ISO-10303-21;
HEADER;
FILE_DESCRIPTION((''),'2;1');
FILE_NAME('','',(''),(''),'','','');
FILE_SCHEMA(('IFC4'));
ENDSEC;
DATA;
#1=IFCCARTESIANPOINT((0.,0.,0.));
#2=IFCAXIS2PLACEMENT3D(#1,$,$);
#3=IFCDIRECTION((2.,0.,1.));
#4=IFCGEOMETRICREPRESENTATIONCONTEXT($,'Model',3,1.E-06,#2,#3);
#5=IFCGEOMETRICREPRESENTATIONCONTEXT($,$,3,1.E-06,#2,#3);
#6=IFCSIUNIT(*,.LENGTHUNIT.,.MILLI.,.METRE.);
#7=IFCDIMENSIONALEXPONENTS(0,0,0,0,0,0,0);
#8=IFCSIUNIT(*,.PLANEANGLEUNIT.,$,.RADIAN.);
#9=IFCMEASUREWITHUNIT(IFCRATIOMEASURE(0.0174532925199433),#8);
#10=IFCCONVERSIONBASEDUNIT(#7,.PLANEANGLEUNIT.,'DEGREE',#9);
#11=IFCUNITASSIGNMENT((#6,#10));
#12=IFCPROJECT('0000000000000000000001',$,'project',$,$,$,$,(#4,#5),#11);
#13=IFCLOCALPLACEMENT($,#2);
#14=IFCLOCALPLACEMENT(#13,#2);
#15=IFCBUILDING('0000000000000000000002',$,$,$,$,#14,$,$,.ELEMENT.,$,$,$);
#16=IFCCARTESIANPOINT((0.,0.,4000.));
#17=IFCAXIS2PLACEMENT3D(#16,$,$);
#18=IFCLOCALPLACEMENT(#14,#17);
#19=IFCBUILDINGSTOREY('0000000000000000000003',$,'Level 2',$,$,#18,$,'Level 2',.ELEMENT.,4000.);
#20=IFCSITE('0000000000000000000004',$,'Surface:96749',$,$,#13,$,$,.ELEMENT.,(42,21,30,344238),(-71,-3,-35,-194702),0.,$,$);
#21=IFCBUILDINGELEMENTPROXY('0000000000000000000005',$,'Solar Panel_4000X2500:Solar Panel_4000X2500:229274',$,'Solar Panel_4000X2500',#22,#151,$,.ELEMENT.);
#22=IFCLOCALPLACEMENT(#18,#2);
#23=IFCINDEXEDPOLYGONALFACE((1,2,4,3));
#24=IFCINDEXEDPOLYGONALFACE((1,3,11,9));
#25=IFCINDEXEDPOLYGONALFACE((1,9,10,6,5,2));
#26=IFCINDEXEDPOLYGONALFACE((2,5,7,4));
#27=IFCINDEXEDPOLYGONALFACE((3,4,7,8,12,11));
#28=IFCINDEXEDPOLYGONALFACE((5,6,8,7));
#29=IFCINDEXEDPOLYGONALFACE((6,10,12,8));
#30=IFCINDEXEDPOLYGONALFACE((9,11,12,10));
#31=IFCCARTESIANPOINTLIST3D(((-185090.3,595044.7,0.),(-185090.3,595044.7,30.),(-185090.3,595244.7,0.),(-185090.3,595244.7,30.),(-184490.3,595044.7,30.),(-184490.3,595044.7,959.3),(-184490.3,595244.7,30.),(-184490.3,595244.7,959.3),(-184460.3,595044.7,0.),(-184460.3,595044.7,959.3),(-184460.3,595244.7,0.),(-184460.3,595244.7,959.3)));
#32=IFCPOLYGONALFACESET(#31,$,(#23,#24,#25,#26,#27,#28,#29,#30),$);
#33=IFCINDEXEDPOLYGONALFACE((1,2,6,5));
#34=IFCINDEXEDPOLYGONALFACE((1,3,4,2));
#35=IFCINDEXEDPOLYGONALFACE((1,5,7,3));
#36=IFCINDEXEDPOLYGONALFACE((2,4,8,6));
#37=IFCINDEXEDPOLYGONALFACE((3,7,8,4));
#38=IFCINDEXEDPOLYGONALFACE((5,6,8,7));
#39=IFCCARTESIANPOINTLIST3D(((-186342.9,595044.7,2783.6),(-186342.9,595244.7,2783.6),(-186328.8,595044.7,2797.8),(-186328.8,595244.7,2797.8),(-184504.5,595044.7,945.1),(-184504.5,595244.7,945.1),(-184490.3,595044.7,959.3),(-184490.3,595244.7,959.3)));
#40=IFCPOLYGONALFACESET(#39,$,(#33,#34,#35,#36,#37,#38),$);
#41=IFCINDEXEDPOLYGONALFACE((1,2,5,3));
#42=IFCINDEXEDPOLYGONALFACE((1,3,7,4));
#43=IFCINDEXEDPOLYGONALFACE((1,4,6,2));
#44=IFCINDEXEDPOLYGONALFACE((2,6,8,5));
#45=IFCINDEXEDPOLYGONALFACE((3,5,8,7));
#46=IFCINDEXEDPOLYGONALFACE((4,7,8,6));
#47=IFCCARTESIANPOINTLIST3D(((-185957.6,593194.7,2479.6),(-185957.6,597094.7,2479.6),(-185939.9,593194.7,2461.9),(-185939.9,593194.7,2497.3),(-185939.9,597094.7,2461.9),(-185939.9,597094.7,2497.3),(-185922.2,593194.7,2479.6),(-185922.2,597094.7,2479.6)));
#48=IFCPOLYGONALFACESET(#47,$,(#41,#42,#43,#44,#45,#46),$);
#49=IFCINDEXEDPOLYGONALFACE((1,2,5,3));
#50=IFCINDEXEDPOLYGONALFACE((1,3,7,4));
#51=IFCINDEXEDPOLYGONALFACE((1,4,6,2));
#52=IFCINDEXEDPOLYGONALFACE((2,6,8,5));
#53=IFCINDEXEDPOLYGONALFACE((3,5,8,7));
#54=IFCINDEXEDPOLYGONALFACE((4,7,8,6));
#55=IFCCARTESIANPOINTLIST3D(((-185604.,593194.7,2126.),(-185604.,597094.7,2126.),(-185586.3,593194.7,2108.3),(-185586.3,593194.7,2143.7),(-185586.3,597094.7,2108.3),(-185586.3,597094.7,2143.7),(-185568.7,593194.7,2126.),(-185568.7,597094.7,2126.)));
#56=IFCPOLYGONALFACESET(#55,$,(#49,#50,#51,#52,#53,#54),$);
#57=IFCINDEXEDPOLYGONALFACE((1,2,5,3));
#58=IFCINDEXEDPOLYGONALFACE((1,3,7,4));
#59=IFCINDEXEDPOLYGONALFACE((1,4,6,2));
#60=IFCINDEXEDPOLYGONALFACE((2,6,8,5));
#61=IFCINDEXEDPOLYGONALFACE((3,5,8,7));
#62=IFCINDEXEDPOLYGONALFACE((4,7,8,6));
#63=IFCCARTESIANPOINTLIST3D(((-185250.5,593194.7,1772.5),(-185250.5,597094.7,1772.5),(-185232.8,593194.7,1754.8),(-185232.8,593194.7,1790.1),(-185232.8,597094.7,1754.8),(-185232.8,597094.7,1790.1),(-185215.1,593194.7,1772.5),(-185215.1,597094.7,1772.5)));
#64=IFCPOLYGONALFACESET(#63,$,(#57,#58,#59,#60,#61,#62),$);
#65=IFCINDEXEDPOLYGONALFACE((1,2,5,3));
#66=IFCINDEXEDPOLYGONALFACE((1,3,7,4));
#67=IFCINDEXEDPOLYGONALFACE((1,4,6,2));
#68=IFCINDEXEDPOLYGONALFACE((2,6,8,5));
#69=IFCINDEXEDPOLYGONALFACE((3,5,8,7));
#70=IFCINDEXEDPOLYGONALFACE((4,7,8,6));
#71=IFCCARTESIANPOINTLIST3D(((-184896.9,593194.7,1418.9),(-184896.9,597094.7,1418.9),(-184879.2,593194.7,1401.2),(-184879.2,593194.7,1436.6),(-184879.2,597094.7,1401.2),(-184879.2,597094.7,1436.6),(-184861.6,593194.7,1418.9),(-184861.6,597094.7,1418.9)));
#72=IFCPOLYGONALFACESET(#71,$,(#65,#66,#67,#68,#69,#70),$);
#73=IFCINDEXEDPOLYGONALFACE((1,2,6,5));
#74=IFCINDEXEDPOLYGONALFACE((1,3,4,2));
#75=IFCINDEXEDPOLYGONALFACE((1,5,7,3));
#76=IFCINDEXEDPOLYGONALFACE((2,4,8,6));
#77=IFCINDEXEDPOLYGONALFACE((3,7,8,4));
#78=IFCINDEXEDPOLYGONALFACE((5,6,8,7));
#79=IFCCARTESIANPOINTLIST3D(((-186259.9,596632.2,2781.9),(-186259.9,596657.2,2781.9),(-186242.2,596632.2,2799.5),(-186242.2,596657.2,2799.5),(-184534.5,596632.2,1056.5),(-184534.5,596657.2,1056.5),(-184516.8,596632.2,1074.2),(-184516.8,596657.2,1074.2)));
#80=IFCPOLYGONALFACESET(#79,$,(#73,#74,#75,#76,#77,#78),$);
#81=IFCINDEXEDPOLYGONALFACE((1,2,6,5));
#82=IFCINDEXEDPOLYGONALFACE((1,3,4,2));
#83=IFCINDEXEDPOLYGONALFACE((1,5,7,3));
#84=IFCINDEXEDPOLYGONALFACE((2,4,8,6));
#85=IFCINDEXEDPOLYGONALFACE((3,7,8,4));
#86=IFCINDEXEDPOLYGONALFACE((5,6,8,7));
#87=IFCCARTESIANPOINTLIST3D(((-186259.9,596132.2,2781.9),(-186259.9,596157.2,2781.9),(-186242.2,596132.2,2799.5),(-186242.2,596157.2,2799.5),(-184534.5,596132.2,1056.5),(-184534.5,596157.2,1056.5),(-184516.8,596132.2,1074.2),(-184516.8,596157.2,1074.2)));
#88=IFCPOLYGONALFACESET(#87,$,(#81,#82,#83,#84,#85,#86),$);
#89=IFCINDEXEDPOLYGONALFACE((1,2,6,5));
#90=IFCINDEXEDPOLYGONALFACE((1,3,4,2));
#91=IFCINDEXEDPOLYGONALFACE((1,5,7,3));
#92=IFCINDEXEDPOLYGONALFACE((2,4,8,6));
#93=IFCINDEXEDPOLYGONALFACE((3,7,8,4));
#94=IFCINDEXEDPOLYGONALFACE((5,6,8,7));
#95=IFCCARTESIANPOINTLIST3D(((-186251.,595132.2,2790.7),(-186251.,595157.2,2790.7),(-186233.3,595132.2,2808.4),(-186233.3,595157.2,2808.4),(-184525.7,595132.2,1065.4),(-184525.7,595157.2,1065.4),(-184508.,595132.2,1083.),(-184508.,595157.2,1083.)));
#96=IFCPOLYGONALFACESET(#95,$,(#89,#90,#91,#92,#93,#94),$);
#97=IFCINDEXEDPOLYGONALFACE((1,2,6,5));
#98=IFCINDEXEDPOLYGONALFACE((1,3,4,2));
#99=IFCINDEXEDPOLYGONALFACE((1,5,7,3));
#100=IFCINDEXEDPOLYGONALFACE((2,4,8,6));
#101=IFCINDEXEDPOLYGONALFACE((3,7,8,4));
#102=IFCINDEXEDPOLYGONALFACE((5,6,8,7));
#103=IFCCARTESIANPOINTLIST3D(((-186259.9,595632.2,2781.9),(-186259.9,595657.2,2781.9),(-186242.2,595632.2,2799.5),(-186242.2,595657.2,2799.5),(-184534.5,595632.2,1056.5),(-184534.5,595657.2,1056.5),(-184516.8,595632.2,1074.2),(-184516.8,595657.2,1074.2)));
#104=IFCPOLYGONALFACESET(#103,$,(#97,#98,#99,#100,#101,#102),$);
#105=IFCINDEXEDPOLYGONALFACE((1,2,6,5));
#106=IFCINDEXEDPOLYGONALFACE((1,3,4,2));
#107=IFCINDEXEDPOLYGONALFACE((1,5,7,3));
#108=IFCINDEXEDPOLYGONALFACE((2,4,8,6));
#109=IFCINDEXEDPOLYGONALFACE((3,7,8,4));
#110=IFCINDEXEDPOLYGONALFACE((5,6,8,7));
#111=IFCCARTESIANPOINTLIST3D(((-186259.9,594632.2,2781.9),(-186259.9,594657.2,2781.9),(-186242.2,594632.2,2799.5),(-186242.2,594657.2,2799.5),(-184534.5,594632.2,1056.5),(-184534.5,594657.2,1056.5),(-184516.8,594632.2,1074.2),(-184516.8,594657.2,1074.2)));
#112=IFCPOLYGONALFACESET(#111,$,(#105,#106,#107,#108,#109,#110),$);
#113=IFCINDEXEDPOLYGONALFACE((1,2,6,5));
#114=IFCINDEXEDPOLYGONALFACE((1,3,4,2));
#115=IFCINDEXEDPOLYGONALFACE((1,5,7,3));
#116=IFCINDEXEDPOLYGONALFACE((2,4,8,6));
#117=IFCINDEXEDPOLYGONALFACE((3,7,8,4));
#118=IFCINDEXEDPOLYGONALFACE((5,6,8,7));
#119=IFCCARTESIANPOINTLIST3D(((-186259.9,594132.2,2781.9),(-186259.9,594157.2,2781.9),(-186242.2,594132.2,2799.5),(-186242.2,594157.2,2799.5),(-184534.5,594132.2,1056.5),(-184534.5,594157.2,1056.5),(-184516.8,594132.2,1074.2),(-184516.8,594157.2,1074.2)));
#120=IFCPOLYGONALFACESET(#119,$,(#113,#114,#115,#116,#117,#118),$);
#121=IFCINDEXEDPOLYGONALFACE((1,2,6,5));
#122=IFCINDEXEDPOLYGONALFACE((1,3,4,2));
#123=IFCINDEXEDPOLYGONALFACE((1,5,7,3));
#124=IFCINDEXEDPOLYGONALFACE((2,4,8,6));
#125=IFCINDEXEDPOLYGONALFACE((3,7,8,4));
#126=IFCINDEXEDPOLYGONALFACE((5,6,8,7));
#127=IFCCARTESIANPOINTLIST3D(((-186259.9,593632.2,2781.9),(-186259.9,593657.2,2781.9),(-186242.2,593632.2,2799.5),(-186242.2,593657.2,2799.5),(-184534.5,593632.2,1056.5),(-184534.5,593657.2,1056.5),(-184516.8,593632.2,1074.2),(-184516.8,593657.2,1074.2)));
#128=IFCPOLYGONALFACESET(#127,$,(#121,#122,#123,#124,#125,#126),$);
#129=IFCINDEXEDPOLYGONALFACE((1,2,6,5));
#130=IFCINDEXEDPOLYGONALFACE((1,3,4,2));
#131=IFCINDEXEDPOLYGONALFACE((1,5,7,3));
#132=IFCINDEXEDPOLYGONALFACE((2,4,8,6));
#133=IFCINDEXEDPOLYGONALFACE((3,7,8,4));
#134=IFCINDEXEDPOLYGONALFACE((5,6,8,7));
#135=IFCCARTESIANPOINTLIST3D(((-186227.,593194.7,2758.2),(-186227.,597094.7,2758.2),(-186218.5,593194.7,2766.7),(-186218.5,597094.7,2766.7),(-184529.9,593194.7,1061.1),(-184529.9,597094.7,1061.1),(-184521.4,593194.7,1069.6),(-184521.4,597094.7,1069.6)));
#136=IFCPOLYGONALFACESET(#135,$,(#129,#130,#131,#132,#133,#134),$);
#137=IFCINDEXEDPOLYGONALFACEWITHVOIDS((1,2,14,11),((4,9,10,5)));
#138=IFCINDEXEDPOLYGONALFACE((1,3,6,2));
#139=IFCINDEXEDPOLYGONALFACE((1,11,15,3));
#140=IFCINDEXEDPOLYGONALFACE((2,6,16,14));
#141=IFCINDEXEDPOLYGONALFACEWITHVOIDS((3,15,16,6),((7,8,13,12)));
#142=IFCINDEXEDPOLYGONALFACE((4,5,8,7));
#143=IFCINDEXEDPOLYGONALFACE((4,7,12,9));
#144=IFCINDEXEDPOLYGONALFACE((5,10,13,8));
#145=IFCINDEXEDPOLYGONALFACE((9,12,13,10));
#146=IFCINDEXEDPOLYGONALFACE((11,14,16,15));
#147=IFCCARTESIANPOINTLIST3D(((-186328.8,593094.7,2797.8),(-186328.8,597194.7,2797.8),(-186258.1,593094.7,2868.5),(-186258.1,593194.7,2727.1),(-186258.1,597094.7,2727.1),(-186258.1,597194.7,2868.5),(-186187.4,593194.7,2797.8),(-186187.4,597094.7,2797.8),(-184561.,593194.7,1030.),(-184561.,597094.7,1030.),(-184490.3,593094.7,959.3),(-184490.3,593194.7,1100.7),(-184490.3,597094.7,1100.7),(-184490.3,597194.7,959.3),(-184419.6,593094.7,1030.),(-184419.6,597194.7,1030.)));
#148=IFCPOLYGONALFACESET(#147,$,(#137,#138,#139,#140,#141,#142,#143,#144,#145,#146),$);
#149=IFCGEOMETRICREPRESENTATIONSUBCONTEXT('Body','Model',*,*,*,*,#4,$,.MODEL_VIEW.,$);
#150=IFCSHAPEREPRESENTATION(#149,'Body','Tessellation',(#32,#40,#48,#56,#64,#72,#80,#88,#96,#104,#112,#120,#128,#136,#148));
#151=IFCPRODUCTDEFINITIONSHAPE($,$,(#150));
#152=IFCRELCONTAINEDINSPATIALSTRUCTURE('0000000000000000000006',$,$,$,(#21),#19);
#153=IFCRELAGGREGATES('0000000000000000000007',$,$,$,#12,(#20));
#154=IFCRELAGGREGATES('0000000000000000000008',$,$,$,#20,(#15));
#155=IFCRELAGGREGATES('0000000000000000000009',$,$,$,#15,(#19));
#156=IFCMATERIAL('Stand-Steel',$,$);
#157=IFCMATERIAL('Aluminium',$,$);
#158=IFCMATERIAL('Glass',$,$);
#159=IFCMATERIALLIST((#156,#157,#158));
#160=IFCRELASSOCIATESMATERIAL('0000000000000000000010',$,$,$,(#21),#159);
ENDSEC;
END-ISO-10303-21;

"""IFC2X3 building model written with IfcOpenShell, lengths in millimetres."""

from ifc_helpers import new_model, entity, si_unit, converted_unit, direction, frame, frame_2d, origin, origin_2d_with_axis, place, context, subcontext, project, spatial, polyline, rectangle, outline, extrude, source, transform, mapped, material, material_list, element, save


model = new_model("IFC2X3")

# Units and contexts
model_context = context("Model", 3, precision=1e-06, world=origin(), true_north=direction((2.0, 0.0, 1.0)))
context_of_model = context(None, 3, precision=1e-06, world=origin(), true_north=direction((2.0, 0.0, 1.0)))
body_context = subcontext(model_context, "Body", "Model", "MODEL_VIEW")
ifc_project = project(units=[si_unit("LENGTHUNIT", "METRE", prefix="MILLI"), converted_unit("PLANEANGLEUNIT", "DEGREE", entity("IfcRatioMeasure", 0.0174532925199433), si_unit("PLANEANGLEUNIT", "RADIAN"), dimensions=[0, 0, 0, 0, 0, 0, 0])], contexts=[model_context, context_of_model])

# Site, building, storey
site_placement = place(None, origin())
site = spatial("IfcSite", under=ifc_project, at=site_placement, Name="Surface:96749", CompositionType="ELEMENT", RefLatitude=(42, 21, 30, 344238), RefLongitude=(-71, -3, -35, -194702), RefElevation=0.0)
building_placement = place(site_placement, origin())
building = spatial("IfcBuilding", under=site, at=building_placement, CompositionType="ELEMENT")
storey_placement = place(building_placement, frame((0.0, 0.0, 4000.0)))
storey = spatial("IfcBuildingStorey", under=building, at=storey_placement, Name="Level 2", LongName="Level 2", CompositionType="ELEMENT", Elevation=4000.0)

# Building element proxy
ifc_material_1 = material(Name="Stand-Steel")
ifc_material_2 = material(Name="Aluminium")
ifc_material_3 = material(Name="Glass")
shared_shape = source(origin(), body_context, "Body", "SweptSolid", [
    extrude(outline(polyline([(-629.5, -220.0), (329.8, -220.0), (329.8, 410.0), (299.8, 410.0), (299.8, -190.0), (-629.5, -190.0), (-629.5, -220.0)])), frame((-190.0, -100.0, 299.8), z_axis=(0.0, 1.0, 0.0), x_axis=(0.0, 0.0, -1.0)), (0.0, 0.0, 1.0), 200.0),
    extrude(rectangle(XDim=20.0, YDim=200.0, at=frame_2d((0.0, 0.0), x_axis=(0.0, 1.0))), frame((-7.1, 0.0, 922.2), z_axis=(-0.707107, 0.0, 0.707107), x_axis=(0.0, 1.0, 0.0)), (0.0, 0.0, 1.0), 2600.0),
    extrude(rectangle(XDim=25.0, YDim=25.0, at=frame_2d((0.0, 0.0), x_axis=(1.0, 0.0))), frame((-1449.6, -1950.0, 2449.6), z_axis=(0.0, 1.0, 0.0), x_axis=(-0.707107, 0.0, -0.707107)), (0.0, 0.0, 1.0), 3900.0),
    extrude(rectangle(XDim=25.0, YDim=25.0, at=origin_2d_with_axis()), frame((-1096.0, -1950.0, 2096.0), z_axis=(0.0, 1.0, 0.0), x_axis=(-0.707107, 0.0, -0.707107)), (0.0, 0.0, 1.0), 3900.0),
    extrude(rectangle(XDim=25.0, YDim=25.0, at=origin_2d_with_axis()), frame((-742.5, -1950.0, 1742.5), z_axis=(0.0, 1.0, 0.0), x_axis=(-0.707107, 0.0, -0.707107)), (0.0, 0.0, 1.0), 3900.0),
    extrude(rectangle(XDim=25.0, YDim=25.0, at=frame_2d((0.0, 0.0), x_axis=(1.0, 0.0))), frame((-388.9, -1950.0, 1388.9), z_axis=(0.0, 1.0, 0.0), x_axis=(-0.707107, 0.0, -0.707107)), (0.0, 0.0, 1.0), 3900.0),
    extrude(rectangle(XDim=25.0, YDim=25.0, at=frame_2d((0.0, 0.0), x_axis=(0.0, 1.0))), frame((-35.4, 1500.0, 1035.4), z_axis=(-0.707107, 0.0, 0.707107), x_axis=(0.0, 1.0, 0.0)), (0.0, 0.0, 1.0), 2440.0),
    extrude(rectangle(XDim=25.0, YDim=25.0, at=frame_2d((0.0, 0.0), x_axis=(0.0, 1.0))), frame((-35.4, 1000.0, 1035.4), z_axis=(-0.707107, 0.0, 0.707107), x_axis=(0.0, 1.0, 0.0)), (0.0, 0.0, 1.0), 2440.0),
    extrude(rectangle(XDim=25.0, YDim=25.0, at=frame_2d((0.0, 0.0), x_axis=(0.0, 1.0))), frame((-26.5, 0.0, 1044.2), z_axis=(-0.707107, 0.0, 0.707107), x_axis=(0.0, -1.0, 0.0)), (0.0, 0.0, 1.0), 2440.0),
    extrude(rectangle(XDim=25.0, YDim=25.0, at=frame_2d((0.0, 0.0), x_axis=(0.0, 1.0))), frame((-35.4, 500.0, 1035.4), z_axis=(-0.707107, 0.0, 0.707107), x_axis=(0.0, 1.0, 0.0)), (0.0, 0.0, 1.0), 2440.0),
    extrude(rectangle(XDim=25.0, YDim=25.0, at=frame_2d((0.0, 0.0), x_axis=(0.0, 1.0))), frame((-35.4, -500.0, 1035.4), z_axis=(-0.707107, 0.0, 0.707107), x_axis=(0.0, 1.0, 0.0)), (0.0, 0.0, 1.0), 2440.0),
    extrude(rectangle(XDim=25.0, YDim=25.0, at=frame_2d((0.0, 0.0), x_axis=(0.0, 1.0))), frame((-35.4, -1000.0, 1035.4), z_axis=(-0.707107, 0.0, 0.707107), x_axis=(0.0, 1.0, 0.0)), (0.0, 0.0, 1.0), 2440.0),
    extrude(rectangle(XDim=25.0, YDim=25.0, at=frame_2d((0.0, 0.0), x_axis=(0.0, 1.0))), frame((-35.4, -1500.0, 1035.4), z_axis=(-0.707107, 0.0, 0.707107), x_axis=(0.0, 1.0, 0.0)), (0.0, 0.0, 1.0), 2440.0),
    extrude(rectangle(XDim=2400.0, YDim=12.0, at=frame_2d((0.0, 0.0), x_axis=(1.0, 0.0))), frame((-883.9, -1950.0, 1883.9), z_axis=(0.0, 1.0, 0.0), x_axis=(0.707107, 0.0, -0.707107)), (0.0, 0.0, 1.0), 3900.0),
    extrude(outline(polyline([(-2050.0, -1300.0), (2050.0, -1300.0), (2050.0, 1300.0), (-2050.0, 1300.0), (-2050.0, -1300.0)]), holes=[polyline([(1950.0, -1200.0), (-1950.0, -1200.0), (-1950.0, 1200.0), (1950.0, 1200.0), (1950.0, -1200.0)])]), frame((-919.2, 0.0, 1848.5), z_axis=(0.707107, 0.0, 0.707107), x_axis=(0.0, 1.0, 0.0)), (0.0, 0.0, 1.0), 100.0),
])
ifc_material_list_1 = material_list([ifc_material_1, ifc_material_2, ifc_material_3])
proxy_1_placement = place(storey_placement, frame((-184490.3, 595144.7, 30.0)))
element("IfcBuildingElementProxy", 1, at=proxy_1_placement, inside=storey, material=ifc_material_list_1, Name="Solar Panel_4000X2500:Solar Panel_4000X2500:229274", ObjectType="Solar Panel_4000X2500", CompositionType="ELEMENT", context=body_context, shape_type="MappedRepresentation", body=[
    mapped(shared_shape, transform((0.0, 0.0, 0.0), scale=1.0)),
])

save(model, "model.ifc")
